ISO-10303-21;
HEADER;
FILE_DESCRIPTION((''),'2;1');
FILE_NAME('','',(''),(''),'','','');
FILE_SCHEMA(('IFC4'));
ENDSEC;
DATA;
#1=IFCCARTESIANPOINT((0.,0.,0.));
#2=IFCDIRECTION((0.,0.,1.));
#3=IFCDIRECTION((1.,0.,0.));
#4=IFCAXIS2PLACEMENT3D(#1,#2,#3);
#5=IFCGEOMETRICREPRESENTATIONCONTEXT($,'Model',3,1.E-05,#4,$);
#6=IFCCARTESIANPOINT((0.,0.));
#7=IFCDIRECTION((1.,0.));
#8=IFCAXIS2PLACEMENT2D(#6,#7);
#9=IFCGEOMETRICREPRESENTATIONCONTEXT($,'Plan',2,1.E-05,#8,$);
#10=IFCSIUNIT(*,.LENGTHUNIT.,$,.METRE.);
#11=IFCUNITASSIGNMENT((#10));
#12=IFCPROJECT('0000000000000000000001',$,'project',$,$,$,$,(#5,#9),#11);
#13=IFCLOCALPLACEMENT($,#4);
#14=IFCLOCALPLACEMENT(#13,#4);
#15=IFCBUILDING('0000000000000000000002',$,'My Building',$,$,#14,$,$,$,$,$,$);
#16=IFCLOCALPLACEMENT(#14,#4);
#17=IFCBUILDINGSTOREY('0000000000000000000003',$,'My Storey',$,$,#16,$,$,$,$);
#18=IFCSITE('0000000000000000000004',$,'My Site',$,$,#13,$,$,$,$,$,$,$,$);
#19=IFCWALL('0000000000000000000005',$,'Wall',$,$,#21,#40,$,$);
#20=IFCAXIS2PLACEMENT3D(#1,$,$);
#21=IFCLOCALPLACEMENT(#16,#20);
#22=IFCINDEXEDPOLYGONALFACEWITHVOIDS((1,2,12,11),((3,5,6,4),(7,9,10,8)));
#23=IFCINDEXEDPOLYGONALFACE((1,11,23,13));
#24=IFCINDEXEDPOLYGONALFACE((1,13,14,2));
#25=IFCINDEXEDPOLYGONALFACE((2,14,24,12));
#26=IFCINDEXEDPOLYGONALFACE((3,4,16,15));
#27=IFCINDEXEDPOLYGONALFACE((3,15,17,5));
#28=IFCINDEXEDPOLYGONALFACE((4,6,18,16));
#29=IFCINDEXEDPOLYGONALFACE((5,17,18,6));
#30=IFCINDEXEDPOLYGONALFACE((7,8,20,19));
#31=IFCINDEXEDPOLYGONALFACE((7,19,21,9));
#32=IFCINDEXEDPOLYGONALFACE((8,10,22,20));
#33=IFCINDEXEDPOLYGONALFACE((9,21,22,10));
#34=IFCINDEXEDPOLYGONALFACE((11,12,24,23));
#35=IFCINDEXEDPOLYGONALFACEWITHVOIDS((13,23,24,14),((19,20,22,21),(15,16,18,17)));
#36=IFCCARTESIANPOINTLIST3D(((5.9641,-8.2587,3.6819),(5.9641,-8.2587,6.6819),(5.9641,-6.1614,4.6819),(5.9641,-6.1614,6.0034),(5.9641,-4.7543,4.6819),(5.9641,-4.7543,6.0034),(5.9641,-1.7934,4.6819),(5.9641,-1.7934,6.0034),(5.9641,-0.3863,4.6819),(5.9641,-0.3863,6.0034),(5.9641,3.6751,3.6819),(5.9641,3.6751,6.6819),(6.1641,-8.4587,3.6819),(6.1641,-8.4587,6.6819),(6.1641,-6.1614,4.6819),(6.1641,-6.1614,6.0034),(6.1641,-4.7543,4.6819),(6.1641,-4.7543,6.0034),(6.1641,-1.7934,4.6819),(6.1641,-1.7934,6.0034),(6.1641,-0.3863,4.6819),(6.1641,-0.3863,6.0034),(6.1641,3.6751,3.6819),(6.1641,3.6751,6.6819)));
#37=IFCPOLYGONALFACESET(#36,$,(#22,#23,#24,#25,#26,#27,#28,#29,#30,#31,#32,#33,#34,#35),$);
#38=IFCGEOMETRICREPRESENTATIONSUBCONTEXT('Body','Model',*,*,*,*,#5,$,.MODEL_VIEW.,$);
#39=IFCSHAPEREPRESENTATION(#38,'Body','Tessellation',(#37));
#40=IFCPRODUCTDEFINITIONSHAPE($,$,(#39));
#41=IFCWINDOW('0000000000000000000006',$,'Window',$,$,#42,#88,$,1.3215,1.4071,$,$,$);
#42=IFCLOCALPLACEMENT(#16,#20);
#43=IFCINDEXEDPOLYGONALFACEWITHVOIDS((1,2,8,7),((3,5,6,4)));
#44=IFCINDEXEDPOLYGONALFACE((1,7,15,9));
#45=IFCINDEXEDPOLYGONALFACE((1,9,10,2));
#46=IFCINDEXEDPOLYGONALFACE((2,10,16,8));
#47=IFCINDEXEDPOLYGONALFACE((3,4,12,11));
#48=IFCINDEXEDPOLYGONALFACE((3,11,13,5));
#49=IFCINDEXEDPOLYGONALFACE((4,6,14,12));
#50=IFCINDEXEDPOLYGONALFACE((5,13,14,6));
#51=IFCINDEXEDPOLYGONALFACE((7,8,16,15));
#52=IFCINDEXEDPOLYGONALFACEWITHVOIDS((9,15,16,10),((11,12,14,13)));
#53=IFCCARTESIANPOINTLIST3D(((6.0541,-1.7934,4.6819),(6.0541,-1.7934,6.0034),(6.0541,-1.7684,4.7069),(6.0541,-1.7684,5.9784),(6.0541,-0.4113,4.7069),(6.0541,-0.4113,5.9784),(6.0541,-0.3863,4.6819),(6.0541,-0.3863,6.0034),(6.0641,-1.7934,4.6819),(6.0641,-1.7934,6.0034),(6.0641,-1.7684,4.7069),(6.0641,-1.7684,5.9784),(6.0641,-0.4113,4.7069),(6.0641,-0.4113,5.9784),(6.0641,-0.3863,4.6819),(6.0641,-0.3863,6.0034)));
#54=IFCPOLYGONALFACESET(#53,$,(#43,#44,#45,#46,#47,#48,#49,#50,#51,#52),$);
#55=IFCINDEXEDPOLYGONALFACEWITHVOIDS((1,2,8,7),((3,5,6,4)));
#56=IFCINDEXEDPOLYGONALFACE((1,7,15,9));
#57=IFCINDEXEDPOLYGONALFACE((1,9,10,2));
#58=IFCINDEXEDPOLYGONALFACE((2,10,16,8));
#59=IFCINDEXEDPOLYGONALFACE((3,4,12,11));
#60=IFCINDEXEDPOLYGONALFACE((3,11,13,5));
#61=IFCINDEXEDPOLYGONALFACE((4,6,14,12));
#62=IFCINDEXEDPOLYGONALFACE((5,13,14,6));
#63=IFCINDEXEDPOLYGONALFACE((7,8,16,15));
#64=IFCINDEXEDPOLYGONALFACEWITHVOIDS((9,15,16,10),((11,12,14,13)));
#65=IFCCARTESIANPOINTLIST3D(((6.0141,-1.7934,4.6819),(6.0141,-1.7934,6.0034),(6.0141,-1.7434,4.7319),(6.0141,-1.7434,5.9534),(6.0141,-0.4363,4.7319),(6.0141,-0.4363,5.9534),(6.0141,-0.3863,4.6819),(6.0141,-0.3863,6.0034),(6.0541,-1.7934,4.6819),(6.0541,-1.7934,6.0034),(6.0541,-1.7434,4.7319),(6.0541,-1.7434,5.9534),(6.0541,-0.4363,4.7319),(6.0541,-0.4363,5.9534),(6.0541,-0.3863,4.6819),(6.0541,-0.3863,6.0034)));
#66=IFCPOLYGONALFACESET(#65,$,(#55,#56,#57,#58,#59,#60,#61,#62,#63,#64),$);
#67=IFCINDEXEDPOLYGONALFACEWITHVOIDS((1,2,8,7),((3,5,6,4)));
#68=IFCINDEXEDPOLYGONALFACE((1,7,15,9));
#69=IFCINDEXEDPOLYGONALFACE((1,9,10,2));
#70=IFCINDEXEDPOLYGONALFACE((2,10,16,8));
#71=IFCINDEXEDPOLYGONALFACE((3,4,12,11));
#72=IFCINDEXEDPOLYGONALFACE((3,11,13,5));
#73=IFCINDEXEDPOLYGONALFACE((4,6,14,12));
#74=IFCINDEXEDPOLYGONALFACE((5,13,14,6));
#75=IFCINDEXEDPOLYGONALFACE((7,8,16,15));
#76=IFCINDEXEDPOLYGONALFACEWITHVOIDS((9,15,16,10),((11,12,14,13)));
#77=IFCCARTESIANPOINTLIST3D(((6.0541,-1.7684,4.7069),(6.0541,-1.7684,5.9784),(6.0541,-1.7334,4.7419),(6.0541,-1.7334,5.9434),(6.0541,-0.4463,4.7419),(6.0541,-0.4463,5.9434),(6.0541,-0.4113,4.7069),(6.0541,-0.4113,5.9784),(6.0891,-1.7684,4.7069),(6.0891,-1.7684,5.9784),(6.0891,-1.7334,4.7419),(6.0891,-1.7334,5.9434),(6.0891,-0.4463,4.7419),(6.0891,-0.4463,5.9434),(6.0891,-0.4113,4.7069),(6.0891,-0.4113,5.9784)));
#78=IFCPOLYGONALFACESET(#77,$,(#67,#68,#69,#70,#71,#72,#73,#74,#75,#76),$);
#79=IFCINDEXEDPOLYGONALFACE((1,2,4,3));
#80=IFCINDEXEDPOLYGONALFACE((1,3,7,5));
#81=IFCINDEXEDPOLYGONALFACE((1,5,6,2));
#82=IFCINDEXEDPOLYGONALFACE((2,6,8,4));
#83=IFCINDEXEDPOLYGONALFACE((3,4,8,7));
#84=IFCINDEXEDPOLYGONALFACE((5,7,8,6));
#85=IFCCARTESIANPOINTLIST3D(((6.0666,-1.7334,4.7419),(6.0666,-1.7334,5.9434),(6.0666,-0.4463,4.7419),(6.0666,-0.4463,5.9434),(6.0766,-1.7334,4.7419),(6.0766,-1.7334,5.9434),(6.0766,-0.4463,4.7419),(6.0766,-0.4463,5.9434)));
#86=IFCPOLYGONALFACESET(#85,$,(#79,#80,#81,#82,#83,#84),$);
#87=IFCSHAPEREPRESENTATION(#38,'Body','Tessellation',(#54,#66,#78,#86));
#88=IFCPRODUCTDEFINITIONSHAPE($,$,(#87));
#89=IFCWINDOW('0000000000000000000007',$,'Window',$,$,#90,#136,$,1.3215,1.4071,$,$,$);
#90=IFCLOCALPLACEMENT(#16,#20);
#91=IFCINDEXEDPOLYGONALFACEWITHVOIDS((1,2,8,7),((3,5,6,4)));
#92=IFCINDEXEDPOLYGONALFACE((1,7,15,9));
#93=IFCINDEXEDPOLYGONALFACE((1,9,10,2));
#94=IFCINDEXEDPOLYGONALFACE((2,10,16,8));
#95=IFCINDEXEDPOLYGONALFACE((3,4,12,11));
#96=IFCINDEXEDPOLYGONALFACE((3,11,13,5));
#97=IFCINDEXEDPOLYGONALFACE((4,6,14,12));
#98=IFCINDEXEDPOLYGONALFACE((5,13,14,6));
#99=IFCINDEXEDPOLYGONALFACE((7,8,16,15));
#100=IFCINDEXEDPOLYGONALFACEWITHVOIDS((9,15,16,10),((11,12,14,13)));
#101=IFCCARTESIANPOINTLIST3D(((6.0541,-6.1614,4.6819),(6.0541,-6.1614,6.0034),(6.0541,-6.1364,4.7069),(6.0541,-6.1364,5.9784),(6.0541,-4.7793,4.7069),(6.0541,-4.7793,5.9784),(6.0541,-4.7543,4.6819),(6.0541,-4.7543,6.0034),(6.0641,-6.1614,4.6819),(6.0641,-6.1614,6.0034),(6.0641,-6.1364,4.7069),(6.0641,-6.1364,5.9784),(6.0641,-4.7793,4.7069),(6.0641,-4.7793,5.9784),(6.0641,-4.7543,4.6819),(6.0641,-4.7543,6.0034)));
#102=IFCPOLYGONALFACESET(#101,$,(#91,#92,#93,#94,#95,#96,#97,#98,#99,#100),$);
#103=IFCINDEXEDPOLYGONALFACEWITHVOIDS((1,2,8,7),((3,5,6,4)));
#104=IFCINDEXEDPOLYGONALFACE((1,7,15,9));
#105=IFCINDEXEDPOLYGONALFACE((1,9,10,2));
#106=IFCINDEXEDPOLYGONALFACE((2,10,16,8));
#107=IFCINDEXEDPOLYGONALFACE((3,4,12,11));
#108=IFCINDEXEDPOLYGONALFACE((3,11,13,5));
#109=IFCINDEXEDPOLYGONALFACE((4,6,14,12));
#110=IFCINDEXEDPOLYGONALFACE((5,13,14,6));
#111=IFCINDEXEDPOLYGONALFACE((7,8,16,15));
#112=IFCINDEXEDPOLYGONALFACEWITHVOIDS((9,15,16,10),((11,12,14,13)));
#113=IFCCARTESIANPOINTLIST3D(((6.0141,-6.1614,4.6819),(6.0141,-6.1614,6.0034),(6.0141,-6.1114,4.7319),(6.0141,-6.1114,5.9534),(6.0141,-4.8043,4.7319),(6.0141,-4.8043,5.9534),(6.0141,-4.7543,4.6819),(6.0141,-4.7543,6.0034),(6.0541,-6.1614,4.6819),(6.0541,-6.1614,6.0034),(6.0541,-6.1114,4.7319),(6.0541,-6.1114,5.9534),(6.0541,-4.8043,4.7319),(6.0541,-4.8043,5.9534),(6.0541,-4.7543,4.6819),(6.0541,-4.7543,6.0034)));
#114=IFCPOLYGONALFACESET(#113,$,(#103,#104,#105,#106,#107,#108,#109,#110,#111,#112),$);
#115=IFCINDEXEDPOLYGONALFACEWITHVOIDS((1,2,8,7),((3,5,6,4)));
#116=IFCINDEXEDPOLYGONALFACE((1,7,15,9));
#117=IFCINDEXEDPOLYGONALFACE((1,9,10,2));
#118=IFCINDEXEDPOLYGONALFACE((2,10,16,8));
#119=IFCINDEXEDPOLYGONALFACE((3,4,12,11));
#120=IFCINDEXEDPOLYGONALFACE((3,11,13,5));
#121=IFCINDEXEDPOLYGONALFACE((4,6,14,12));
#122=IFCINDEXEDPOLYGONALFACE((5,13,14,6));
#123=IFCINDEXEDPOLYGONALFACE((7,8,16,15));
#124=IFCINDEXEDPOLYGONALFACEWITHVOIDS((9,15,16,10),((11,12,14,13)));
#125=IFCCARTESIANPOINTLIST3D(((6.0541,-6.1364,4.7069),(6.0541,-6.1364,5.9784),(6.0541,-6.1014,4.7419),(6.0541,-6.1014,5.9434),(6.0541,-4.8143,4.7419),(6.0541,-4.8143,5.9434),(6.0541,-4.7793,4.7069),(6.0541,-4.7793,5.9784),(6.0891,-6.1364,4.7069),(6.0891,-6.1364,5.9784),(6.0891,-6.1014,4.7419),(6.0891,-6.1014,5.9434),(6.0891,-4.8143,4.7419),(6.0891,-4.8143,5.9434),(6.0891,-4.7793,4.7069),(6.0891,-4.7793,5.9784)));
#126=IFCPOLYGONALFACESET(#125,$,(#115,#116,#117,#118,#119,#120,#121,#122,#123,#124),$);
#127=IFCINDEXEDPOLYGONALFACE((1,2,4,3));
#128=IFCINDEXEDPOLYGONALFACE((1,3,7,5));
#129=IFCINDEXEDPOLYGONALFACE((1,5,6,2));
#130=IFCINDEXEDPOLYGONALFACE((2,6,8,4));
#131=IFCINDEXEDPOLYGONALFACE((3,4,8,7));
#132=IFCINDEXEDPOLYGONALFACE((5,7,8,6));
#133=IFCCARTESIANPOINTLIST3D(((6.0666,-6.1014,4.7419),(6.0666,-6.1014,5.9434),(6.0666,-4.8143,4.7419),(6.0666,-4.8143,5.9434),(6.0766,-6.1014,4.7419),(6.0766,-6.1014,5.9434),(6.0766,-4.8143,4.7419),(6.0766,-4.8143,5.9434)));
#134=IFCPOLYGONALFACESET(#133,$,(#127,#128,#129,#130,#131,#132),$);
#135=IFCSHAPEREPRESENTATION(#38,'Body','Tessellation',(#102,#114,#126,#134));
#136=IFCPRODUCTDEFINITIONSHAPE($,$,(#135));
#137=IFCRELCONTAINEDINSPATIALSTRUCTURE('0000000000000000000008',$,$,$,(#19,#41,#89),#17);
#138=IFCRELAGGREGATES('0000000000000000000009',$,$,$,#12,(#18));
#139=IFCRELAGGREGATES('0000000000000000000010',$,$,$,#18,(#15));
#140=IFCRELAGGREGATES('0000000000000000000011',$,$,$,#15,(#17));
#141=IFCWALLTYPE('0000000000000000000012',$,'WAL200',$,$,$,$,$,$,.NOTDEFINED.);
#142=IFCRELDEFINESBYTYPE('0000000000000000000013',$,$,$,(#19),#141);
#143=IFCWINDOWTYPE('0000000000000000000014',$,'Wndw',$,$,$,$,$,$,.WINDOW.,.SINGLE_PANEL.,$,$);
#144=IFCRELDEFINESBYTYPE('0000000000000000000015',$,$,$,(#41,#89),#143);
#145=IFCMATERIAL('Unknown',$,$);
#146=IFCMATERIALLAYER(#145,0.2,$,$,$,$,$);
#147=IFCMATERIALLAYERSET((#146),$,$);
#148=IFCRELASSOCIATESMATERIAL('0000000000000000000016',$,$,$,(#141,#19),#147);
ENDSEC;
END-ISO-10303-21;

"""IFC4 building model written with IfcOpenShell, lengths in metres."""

from ifc_helpers import new_model, entity, si_unit, frame, origin_with_axes, origin_2d_with_axis, place, context, subcontext, project, spatial, line, indexed_curve, outline, extrude, shape, source, transform, mapped, material, layer, layer_set, layer_usage, type_object, type_shapes, element, fill, save


model = new_model("IFC4")

# Units and contexts
model_context = context("Model", 3, precision=1e-05, world=origin_with_axes())
plan_context = context("Plan", 2, precision=1e-05, world=origin_2d_with_axis())
body_context_1 = subcontext(model_context, "Body", "Model", "MODEL_VIEW")
body_context_2 = subcontext(plan_context, "Body", "Plan", "PLAN_VIEW")
ifc_project = project(units=[si_unit("LENGTHUNIT", "METRE")], contexts=[model_context, plan_context])

# Site, building, storey
site_placement = place(None, origin_with_axes())
site = spatial("IfcSite", under=ifc_project, at=site_placement, Name="My Site")
building_placement = place(site_placement, origin_with_axes())
building = spatial("IfcBuilding", under=site, at=building_placement, Name="My Building")
storey_placement = place(building_placement, origin_with_axes())
storey = spatial("IfcBuildingStorey", under=building, at=storey_placement, Name="My Storey")

# Shared definitions
ifc_material = material(Name="Unknown")
ifc_layer = layer(ifc_material, 0.2)
ifc_layer_set = layer_set([ifc_layer])
wall_type = type_object("IfcWallType", Name="WAL200", PredefinedType="NOTDEFINED", material=ifc_layer_set)
shared_shape_1 = source(origin_with_axes(), body_context_1, "Body", "SweptSolid", [
    extrude(outline(indexed_curve([(0.0, 0.0), (1.4071, 0.0), (1.4071, 1.3215), (0.0, 1.3215)], segments=[line(1, 2, 3, 4, 1)])), frame((0.0, -0.6, 0.0), z_axis=(0.0, -1.0, 0.0), x_axis=(1.0, 0.0, 0.0)), (0.0, 0.0, -1.0), 1.2),
])
window_type = type_object("IfcWindowType", Name="Wndw", PartitioningType="SINGLE_PANEL", PredefinedType="WINDOW")
shared_shape_2 = source(origin_with_axes(), body_context_1, "Body", "SweptSolid", [
    extrude(outline(indexed_curve([(0.0, 0.0), (1.4071, 0.0), (1.4071, 1.3215), (0.0, 1.3215)], segments=[line(1, 2, 3, 4, 1)]), holes=[indexed_curve([(0.025, 0.025), (1.3821, 0.025), (1.3821, 1.2965), (0.025, 1.2965)], segments=[line(1, 2, 3, 4, 1)])]), frame((0.0, 0.09, 0.0), z_axis=(0.0, -1.0, 0.0), x_axis=(1.0, 0.0, 0.0)), (0.0, 0.0, -1.0), 0.01),
    extrude(outline(indexed_curve([(0.0, 0.0), (1.4071, 0.0), (1.4071, 1.3215), (0.0, 1.3215)], segments=[line(1, 2, 3, 4, 1)]), holes=[indexed_curve([(0.05, 0.05), (1.3571, 0.05), (1.3571, 1.2715), (0.05, 1.2715)], segments=[line(1, 2, 3, 4, 1)])]), frame((0.0, 0.05, 0.0), z_axis=(0.0, -1.0, 0.0), x_axis=(1.0, 0.0, 0.0)), (0.0, 0.0, -1.0), 0.04),
    extrude(outline(indexed_curve([(0.0, 0.0), (1.3571, 0.0), (1.3571, 1.2715), (0.0, 1.2715)], segments=[line(1, 2, 3, 4, 1)]), holes=[indexed_curve([(0.035, 0.035), (1.3221, 0.035), (1.3221, 1.2365), (0.035, 1.2365)], segments=[line(1, 2, 3, 4, 1)])]), frame((0.025, 0.09, 0.025), z_axis=(0.0, -1.0, 0.0), x_axis=(1.0, 0.0, 0.0)), (0.0, 0.0, -1.0), 0.035),
    extrude(outline(indexed_curve([(0.035, 0.035), (1.3221, 0.035), (1.3221, 1.2365), (0.035, 1.2365)], segments=[line(1, 2, 3, 4, 1)])), frame((0.025, 0.1025, 0.025), z_axis=(0.0, -1.0, 0.0), x_axis=(1.0, 0.0, 0.0)), (0.0, 0.0, -1.0), 0.01),
])
shared_shape_3 = source(origin_with_axes(), body_context_2, "Body", "Curve2D", [
    entity("IfcIndexedPolyCurve", entity("IfcCartesianPointList2D", [[0.05, 0.05], [1.3571, 0.05]])),
    entity("IfcIndexedPolyCurve", entity("IfcCartesianPointList2D", [[0.0, 0.1], [0.025, 0.1], [0.025, 0.09], [0.05, 0.09], [0.05, 0.05], [0.0, 0.05]]), [entity("IfcLineIndex", [1, 2, 3, 4, 5, 6, 1])]),
    entity("IfcIndexedPolyCurve", entity("IfcCartesianPointList2D", [[1.4071, 0.1], [1.3821, 0.1], [1.3821, 0.09], [1.3571, 0.09], [1.3571, 0.05], [1.4071, 0.05]]), [entity("IfcLineIndex", [1, 2, 3, 4, 5, 6, 1])]),
    entity("IfcIndexedPolyCurve", entity("IfcCartesianPointList2D", [[0.025, 0.09], [0.06, 0.09], [0.06, 0.125], [0.025, 0.125]]), [entity("IfcLineIndex", [1, 2, 3, 4, 1])]),
    entity("IfcIndexedPolyCurve", entity("IfcCartesianPointList2D", [[1.3821, 0.09], [1.3471, 0.09], [1.3471, 0.125], [1.3821, 0.125]]), [entity("IfcLineIndex", [1, 2, 3, 4, 1])]),
    entity("IfcIndexedPolyCurve", entity("IfcCartesianPointList2D", [[0.06, 0.09], [1.3471, 0.09]])),
    entity("IfcIndexedPolyCurve", entity("IfcCartesianPointList2D", [[0.06, 0.125], [1.3471, 0.125]])),
    entity("IfcIndexedPolyCurve", entity("IfcCartesianPointList2D", [[0.06, 0.1075], [1.3471, 0.1075]])),
])
type_shapes(window_type, [shared_shape_2, shared_shape_3])

# Wall, openings, windows
ifc_layer_usage_1 = layer_usage(ifc_layer_set, "AXIS2", "POSITIVE", 0.0)
wall_1_placement = place(storey_placement, frame((6.1641, -8.4587, 3.6819), z_axis=(0.0, 0.0, 1.0), x_axis=(0.0, 1.0, 0.0)))
wall_1 = element("IfcWall", 1, at=wall_1_placement, inside=storey, type_object=wall_type, material=ifc_layer_usage_1, Name="Wall", context=body_context_1, shape_type="SweptSolid", body=[
    extrude(outline(indexed_curve([(0.0, 0.0), (0.2, 0.2), (12.1338, 0.2), (12.1338, 0.0)], segments=[line(1, 2, 3, 4, 1)])), origin_with_axes(), (0.0, 0.0, 1.0), 3.0),
])
opening_1_placement = place(wall_1_placement, frame((8.0724, 0.2, 1.0), z_axis=(0.0, 0.0, 1.0), x_axis=(-1.0, 0.0, 0.0)))
opening_1 = element("IfcOpeningElement", 2, at=opening_1_placement, cuts=wall_1, PredefinedType="OPENING", context=body_context_1, shape_type="MappedRepresentation", body=[
    mapped(shared_shape_1, transform((0.0, 0.0, 0.0), x_axis=(1.0, 0.0, 0.0), y_axis=(0.0, 1.0, 0.0), z_axis=(0.0, 0.0, 1.0), scale=1.0)),
])
opening_2_placement = place(wall_1_placement, frame((3.7044, 0.2, 1.0), z_axis=(0.0, 0.0, 1.0), x_axis=(-1.0, 0.0, 0.0)))
opening_2 = element("IfcOpeningElement", 3, at=opening_2_placement, cuts=wall_1, PredefinedType="OPENING", context=body_context_1, shape_type="MappedRepresentation", body=[
    mapped(shared_shape_1, transform((0.0, 0.0, 0.0), x_axis=(1.0, 0.0, 0.0), y_axis=(0.0, 1.0, 0.0), z_axis=(0.0, 0.0, 1.0), scale=1.0)),
])
window_1_placement = place(opening_1_placement, frame((0.0, 0.0, 0.0), z_axis=(0.0, 0.0, 1.0), x_axis=(1.0, 0.0, 0.0)))
window_1 = element("IfcWindow", 4, at=window_1_placement, inside=storey, type_object=window_type, Name="Window", OverallHeight=1.3215, OverallWidth=1.4071, shapes=[
    shape(body_context_1, "Body", "MappedRepresentation", [mapped(shared_shape_2, transform((0.0, 0.0, 0.0), x_axis=(1.0, 0.0, 0.0), y_axis=(0.0, 1.0, 0.0), z_axis=(0.0, 0.0, 1.0), scale=1.0))]),
    shape(body_context_2, "Body", "MappedRepresentation", [mapped(shared_shape_3, transform((0.0, 0.0, 0.0), x_axis=(1.0, 0.0, 0.0), y_axis=(0.0, 1.0, 0.0), z_axis=(0.0, 0.0, 1.0), scale=1.0))]),
])
fill(opening_1, window_1)
window_2_placement = place(opening_2_placement, frame((0.0, 0.0, 0.0), z_axis=(0.0, 0.0, 1.0), x_axis=(1.0, 0.0, 0.0)))
window_2 = element("IfcWindow", 5, at=window_2_placement, inside=storey, type_object=window_type, Name="Window", OverallHeight=1.3215, OverallWidth=1.4071, shapes=[
    shape(body_context_1, "Body", "MappedRepresentation", [mapped(shared_shape_2, transform((0.0, 0.0, 0.0), x_axis=(1.0, 0.0, 0.0), y_axis=(0.0, 1.0, 0.0), z_axis=(0.0, 0.0, 1.0), scale=1.0))]),
    shape(body_context_2, "Body", "MappedRepresentation", [mapped(shared_shape_3, transform((0.0, 0.0, 0.0), x_axis=(1.0, 0.0, 0.0), y_axis=(0.0, 1.0, 0.0), z_axis=(0.0, 0.0, 1.0), scale=1.0))]),
])
fill(opening_2, window_2)

save(model, "model.ifc")
